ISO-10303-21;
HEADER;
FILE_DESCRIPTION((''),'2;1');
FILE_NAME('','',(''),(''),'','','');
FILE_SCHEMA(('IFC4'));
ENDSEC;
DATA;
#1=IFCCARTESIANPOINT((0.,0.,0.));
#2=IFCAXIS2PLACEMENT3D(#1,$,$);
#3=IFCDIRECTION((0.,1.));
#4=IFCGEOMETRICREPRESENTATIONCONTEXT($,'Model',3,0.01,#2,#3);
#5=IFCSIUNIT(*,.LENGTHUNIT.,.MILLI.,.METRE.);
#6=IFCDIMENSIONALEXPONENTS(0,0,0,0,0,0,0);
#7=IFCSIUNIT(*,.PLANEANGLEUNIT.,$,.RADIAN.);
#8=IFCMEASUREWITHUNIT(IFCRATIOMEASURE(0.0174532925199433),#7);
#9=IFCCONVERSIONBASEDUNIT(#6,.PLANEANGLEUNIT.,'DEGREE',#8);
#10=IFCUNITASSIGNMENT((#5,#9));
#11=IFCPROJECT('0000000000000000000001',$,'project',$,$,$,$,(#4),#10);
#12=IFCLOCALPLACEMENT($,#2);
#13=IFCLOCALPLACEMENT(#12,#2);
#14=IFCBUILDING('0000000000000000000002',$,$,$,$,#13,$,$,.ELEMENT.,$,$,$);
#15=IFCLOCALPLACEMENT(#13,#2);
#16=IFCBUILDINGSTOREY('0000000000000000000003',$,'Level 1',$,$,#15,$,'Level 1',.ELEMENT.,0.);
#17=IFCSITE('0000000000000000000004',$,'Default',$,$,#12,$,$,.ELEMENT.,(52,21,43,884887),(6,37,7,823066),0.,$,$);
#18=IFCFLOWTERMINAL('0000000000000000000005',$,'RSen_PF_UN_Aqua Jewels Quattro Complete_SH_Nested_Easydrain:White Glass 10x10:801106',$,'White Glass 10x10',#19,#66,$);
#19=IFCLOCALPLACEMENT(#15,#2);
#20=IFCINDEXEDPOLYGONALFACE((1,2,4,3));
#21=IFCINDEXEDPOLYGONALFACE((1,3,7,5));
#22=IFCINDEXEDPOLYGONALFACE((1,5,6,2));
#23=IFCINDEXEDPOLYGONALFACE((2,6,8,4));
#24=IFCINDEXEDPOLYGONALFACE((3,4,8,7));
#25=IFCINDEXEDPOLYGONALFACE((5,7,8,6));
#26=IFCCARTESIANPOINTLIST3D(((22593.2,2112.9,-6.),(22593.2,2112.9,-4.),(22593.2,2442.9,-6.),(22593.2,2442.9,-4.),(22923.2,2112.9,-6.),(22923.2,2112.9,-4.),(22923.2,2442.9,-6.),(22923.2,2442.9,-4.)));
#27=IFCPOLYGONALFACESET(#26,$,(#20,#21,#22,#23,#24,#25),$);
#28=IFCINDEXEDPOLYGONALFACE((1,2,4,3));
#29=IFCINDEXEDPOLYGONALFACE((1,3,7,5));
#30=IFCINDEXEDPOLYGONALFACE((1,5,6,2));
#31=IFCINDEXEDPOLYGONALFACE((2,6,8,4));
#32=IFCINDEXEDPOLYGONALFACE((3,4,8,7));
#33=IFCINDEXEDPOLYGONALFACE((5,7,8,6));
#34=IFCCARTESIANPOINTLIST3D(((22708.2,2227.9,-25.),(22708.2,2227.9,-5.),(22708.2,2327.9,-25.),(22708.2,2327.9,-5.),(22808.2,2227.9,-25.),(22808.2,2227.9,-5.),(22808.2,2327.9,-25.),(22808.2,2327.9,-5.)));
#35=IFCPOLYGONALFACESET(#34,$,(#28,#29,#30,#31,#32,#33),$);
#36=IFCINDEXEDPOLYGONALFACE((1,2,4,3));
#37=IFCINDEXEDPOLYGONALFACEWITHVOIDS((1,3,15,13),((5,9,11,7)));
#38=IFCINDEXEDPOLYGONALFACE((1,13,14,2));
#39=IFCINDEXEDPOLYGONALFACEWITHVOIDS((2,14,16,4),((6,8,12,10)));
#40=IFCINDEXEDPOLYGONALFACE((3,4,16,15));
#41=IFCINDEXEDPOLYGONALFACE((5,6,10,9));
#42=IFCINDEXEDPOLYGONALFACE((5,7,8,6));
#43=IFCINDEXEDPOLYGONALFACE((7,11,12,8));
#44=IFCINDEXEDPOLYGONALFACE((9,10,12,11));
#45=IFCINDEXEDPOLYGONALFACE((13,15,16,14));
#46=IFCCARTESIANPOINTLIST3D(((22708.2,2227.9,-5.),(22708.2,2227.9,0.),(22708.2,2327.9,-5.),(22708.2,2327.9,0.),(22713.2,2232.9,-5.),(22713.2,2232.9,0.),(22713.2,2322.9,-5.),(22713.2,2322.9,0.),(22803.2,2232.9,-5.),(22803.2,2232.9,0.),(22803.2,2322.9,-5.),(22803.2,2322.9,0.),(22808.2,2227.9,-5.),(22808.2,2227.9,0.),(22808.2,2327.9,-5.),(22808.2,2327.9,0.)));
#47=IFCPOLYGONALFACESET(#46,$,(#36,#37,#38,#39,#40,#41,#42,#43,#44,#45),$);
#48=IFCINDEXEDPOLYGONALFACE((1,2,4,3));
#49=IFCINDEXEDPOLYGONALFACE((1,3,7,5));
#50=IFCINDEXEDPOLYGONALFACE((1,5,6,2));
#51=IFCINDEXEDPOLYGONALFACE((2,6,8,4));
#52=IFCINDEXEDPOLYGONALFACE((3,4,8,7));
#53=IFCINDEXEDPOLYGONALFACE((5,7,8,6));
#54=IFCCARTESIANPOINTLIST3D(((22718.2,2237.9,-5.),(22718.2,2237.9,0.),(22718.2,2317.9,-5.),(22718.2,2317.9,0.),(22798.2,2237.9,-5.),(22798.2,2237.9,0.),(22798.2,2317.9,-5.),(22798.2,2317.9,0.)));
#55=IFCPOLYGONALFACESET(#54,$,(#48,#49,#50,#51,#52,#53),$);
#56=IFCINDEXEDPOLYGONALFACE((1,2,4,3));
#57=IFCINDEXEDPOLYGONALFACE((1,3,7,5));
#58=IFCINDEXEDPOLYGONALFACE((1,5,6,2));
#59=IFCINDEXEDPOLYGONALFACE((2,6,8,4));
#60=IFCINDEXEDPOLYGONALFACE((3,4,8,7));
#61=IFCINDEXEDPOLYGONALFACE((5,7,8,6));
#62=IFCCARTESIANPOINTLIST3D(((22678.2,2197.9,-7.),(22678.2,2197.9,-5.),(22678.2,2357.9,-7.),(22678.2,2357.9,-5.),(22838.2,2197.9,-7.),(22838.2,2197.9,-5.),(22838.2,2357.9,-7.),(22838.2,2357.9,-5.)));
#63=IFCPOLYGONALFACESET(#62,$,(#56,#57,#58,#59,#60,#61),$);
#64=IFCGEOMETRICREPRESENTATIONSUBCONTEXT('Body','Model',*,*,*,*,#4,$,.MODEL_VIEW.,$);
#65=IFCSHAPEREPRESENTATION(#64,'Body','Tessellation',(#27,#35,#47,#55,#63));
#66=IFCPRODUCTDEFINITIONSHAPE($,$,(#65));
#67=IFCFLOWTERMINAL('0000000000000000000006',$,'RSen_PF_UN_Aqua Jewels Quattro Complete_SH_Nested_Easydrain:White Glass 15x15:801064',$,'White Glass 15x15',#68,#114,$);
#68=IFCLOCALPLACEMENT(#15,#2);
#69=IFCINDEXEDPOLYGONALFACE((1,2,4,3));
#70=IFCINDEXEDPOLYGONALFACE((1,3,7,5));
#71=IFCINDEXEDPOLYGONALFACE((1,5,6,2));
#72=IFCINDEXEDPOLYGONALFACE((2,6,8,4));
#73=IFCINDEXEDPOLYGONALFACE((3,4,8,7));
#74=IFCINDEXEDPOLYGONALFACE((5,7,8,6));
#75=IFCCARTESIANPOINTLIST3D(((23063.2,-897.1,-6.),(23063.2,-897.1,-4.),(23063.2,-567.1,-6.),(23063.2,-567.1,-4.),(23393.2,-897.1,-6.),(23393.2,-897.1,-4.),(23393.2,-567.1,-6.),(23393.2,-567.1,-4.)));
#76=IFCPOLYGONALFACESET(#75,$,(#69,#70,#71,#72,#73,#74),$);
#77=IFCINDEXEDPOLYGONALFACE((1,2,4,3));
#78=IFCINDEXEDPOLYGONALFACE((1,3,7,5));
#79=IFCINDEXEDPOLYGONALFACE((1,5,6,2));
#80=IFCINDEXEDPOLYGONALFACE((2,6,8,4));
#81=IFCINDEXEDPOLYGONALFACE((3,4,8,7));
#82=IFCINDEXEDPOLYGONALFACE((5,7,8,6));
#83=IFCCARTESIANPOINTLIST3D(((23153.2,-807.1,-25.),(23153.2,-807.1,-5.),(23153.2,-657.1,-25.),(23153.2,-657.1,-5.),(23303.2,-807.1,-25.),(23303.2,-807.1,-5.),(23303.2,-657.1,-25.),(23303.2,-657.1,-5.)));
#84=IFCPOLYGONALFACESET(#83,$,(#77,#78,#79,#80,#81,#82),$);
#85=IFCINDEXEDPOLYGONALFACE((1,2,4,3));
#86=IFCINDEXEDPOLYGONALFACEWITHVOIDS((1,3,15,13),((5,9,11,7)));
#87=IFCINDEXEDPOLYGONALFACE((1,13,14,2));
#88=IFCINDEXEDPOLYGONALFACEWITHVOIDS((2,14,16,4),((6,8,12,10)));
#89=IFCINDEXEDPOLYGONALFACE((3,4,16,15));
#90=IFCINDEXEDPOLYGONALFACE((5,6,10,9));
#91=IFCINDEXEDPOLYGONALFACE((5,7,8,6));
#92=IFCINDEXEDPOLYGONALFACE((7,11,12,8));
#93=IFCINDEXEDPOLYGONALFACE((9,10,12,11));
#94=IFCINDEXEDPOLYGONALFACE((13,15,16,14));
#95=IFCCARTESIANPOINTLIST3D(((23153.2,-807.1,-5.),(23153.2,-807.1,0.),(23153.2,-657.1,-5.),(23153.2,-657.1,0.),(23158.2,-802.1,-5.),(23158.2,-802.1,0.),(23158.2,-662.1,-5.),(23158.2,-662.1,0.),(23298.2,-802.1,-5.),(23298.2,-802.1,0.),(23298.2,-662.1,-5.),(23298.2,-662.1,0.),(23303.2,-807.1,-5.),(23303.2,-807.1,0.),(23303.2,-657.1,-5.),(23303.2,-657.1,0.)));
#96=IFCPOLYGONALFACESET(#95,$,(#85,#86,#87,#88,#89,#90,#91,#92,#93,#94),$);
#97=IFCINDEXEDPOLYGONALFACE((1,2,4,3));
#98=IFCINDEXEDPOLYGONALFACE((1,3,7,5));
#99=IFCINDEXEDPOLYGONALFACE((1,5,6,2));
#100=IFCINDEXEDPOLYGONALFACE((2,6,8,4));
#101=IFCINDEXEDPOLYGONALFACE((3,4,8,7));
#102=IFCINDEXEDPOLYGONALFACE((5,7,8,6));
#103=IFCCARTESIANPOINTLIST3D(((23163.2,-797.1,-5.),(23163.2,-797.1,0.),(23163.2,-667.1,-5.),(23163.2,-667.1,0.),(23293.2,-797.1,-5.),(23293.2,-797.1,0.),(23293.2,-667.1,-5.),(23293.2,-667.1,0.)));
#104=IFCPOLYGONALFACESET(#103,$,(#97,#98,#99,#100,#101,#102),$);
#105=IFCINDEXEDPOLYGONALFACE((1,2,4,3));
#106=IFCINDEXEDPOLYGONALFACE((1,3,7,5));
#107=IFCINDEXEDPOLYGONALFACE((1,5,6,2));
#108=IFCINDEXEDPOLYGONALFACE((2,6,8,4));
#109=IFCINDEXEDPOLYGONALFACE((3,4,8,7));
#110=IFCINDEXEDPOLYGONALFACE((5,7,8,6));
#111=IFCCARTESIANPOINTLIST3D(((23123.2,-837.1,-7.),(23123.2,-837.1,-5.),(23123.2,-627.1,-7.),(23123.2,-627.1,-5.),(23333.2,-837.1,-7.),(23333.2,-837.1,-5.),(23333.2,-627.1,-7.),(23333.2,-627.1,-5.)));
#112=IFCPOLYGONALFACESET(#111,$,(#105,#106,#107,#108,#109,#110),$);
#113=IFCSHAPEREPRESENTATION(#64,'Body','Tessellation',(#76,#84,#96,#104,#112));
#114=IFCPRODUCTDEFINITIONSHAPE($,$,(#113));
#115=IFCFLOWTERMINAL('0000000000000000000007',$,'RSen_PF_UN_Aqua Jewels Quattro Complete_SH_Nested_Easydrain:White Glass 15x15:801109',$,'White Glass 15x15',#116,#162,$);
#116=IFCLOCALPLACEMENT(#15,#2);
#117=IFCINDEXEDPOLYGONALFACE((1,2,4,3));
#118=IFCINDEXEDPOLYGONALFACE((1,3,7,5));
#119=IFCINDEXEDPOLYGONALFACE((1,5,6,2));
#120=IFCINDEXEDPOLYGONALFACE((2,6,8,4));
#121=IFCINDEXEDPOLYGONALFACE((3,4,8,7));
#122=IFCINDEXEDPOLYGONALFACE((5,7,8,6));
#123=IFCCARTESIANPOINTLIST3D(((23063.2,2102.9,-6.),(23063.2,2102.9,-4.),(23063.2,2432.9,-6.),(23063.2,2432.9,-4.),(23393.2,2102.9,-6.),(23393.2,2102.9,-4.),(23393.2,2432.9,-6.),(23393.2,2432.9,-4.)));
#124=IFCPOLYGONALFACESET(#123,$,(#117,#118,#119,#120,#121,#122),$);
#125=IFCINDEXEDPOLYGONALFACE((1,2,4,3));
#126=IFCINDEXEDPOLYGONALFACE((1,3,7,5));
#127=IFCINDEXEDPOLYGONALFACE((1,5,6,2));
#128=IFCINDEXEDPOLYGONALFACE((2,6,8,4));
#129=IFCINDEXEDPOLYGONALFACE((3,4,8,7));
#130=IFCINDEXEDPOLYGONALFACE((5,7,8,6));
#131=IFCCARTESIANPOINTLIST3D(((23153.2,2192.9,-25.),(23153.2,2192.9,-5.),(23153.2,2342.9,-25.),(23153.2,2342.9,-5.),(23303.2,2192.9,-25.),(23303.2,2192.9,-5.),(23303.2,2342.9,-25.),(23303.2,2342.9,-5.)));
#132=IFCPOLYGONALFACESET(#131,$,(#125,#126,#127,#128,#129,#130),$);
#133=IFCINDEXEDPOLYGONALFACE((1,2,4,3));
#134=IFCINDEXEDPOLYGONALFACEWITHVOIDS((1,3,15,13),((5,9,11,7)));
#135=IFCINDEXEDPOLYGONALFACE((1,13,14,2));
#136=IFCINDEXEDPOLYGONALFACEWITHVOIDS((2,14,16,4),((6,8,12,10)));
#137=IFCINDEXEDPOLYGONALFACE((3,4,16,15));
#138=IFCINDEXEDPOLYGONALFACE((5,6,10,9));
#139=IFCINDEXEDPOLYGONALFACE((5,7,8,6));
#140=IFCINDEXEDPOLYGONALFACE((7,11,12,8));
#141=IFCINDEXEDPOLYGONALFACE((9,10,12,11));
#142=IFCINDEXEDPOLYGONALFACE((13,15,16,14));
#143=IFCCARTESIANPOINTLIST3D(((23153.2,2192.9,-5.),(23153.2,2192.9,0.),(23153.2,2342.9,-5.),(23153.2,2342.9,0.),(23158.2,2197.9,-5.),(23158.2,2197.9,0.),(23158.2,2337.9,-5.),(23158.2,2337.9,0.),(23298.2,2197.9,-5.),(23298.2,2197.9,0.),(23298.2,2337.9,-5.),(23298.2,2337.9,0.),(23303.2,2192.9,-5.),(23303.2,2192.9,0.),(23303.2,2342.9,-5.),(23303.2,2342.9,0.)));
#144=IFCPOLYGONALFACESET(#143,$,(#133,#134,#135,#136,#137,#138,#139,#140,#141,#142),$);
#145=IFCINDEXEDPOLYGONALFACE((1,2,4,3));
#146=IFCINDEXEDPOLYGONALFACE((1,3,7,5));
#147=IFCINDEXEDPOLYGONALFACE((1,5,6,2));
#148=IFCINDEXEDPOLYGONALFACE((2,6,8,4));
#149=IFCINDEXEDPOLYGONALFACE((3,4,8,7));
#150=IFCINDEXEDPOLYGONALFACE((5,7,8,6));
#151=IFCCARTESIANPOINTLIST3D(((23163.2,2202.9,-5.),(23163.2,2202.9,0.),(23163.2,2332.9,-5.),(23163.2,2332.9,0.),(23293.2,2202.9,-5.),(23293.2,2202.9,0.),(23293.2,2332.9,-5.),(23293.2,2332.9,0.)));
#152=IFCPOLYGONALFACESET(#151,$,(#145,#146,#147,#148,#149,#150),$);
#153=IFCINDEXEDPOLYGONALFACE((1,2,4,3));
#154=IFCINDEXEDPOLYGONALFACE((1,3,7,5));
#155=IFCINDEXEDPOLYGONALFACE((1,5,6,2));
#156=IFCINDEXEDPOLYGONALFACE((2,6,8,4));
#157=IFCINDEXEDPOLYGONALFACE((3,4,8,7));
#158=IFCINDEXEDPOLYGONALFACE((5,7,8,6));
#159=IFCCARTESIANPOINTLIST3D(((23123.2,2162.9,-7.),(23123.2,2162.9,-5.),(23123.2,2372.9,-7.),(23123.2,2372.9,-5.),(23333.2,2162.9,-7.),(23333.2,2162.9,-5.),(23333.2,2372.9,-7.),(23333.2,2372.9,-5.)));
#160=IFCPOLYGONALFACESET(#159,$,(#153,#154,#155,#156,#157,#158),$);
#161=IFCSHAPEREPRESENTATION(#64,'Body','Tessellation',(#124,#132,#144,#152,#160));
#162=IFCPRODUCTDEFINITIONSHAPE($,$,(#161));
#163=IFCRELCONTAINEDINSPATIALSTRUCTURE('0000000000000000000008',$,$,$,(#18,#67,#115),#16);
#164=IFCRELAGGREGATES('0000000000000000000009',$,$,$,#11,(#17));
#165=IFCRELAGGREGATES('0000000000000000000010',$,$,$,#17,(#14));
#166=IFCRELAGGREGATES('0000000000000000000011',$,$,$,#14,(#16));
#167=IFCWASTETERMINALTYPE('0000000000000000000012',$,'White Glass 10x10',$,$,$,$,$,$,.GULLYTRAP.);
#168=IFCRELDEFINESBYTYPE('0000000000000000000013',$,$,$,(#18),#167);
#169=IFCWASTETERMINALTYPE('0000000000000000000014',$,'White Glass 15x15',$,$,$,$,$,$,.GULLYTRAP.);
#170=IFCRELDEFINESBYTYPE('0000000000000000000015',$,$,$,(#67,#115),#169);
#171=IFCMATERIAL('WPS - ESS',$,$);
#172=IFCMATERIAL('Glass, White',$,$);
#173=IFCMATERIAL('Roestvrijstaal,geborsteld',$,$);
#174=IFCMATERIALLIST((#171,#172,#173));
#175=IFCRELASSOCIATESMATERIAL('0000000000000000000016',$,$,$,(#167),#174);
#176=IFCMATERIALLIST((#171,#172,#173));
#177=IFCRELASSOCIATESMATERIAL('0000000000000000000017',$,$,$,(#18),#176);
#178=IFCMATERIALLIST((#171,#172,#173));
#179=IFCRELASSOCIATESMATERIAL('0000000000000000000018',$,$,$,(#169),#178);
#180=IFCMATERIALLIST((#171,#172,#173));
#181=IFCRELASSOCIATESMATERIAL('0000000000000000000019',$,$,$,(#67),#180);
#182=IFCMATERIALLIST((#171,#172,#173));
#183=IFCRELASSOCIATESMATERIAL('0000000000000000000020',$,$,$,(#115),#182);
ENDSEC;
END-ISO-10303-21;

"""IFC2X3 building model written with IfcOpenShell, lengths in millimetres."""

from ifc_helpers import new_model, entity, si_unit, converted_unit, direction, frame, frame_2d, origin, origin_2d_with_axis, place, context, subcontext, project, spatial, polyline, rectangle, outline, extrude, source, transform, mapped, material, material_list, type_object, type_shapes, element, save


model = new_model("IFC2X3")

# Units and contexts
model_context = context("Model", 3, precision=0.01, world=origin(), true_north=direction((0.0, 1.0)))
body_context = subcontext(model_context, "Body", "Model", "MODEL_VIEW")
ifc_project = project(units=[si_unit("LENGTHUNIT", "METRE", prefix="MILLI"), converted_unit("PLANEANGLEUNIT", "DEGREE", entity("IfcRatioMeasure", 0.0174532925199433), si_unit("PLANEANGLEUNIT", "RADIAN"), dimensions=[0, 0, 0, 0, 0, 0, 0])], contexts=[model_context])

# Site, building, storey
site_placement = place(None, origin())
site = spatial("IfcSite", under=ifc_project, at=site_placement, Name="Default", CompositionType="ELEMENT", RefLatitude=(52, 21, 43, 884887), RefLongitude=(6, 37, 7, 823066), RefElevation=0.0)
building_placement = place(site_placement, origin())
building = spatial("IfcBuilding", under=site, at=building_placement, CompositionType="ELEMENT")
storey_placement = place(building_placement, origin())
storey = spatial("IfcBuildingStorey", under=building, at=storey_placement, Name="Level 1", LongName="Level 1", CompositionType="ELEMENT", Elevation=0.0)

# Flow terminals
ifc_material_1 = material(Name="WPS - ESS")
ifc_material_2 = material(Name="Roestvrijstaal,geborsteld")
ifc_material_3 = material(Name="Glass, White")
ifc_material_list_1 = material_list([ifc_material_1, ifc_material_3, ifc_material_2])
waste_terminal_type_1 = type_object("IfcWasteTerminalType", Name="White Glass 10x10", PredefinedType="GULLYTRAP", material=ifc_material_list_1)
shared_shape_1 = source(origin(), body_context, "Body", "SweptSolid", [
    extrude(rectangle(XDim=330.0, YDim=330.0, at=origin_2d_with_axis()), frame((0.0, 0.0, -6.0), z_axis=(0.0, 0.0, 1.0), x_axis=(-1.0, 0.0, 0.0)), (0.0, 0.0, 1.0), 2.0),
    extrude(rectangle(XDim=100.0, YDim=100.0, at=origin_2d_with_axis()), frame((0.0, 0.0, -25.0), z_axis=(0.0, 0.0, 1.0), x_axis=(-1.0, 0.0, 0.0)), (0.0, 0.0, 1.0), 20.0),
    extrude(outline(polyline([(-50.0, -50.0), (50.0, -50.0), (50.0, 50.0), (-50.0, 50.0), (-50.0, -50.0)]), holes=[polyline([(-45.0, -45.0), (-45.0, 45.0), (45.0, 45.0), (45.0, -45.0), (-45.0, -45.0)])]), frame((0.0, 0.0, -5.0), z_axis=(0.0, 0.0, 1.0), x_axis=(-1.0, 0.0, 0.0)), (0.0, 0.0, 1.0), 5.0),
    extrude(rectangle(XDim=80.0, YDim=80.0, at=origin_2d_with_axis()), frame((0.0, 0.0, -5.0), z_axis=(0.0, 0.0, 1.0), x_axis=(-1.0, 0.0, 0.0)), (0.0, 0.0, 1.0), 5.0),
    extrude(rectangle(XDim=160.0, YDim=160.0, at=origin_2d_with_axis()), frame((0.0, 0.0, -7.0), z_axis=(0.0, 0.0, 1.0), x_axis=(-1.0, 0.0, 0.0)), (0.0, 0.0, 1.0), 2.0),
])
type_shapes(waste_terminal_type_1, [shared_shape_1])
ifc_material_list_2 = material_list([ifc_material_1, ifc_material_3, ifc_material_2])
flow_terminal_1_placement = place(storey_placement, frame((22758.2, 2277.9, 0.0)))
element("IfcFlowTerminal", 1, at=flow_terminal_1_placement, inside=storey, type_object=waste_terminal_type_1, material=ifc_material_list_2, Name="RSen_PF_UN_Aqua Jewels Quattro Complete_SH_Nested_Easydrain:White Glass 10x10:801106", ObjectType="White Glass 10x10", context=body_context, shape_type="MappedRepresentation", body=[
    mapped(shared_shape_1, transform((0.0, 0.0, 0.0), scale=1.0)),
])
ifc_material_list_3 = material_list([ifc_material_1, ifc_material_3, ifc_material_2])
ifc_material_list_4 = material_list([ifc_material_1, ifc_material_3, ifc_material_2])
waste_terminal_type_2 = type_object("IfcWasteTerminalType", Name="White Glass 15x15", PredefinedType="GULLYTRAP", material=ifc_material_list_4)
shared_shape_2 = source(origin(), body_context, "Body", "SweptSolid", [
    extrude(rectangle(XDim=330.0, YDim=330.0, at=origin_2d_with_axis()), frame((5.0, -10.0, -6.0), z_axis=(0.0, 0.0, 1.0), x_axis=(-1.0, 0.0, 0.0)), (0.0, 0.0, 1.0), 2.0),
    extrude(rectangle(XDim=150.0, YDim=150.0, at=origin_2d_with_axis()), frame((5.0, -10.0, -25.0), z_axis=(0.0, 0.0, 1.0), x_axis=(-1.0, 0.0, 0.0)), (0.0, 0.0, 1.0), 20.0),
    extrude(outline(polyline([(-75.0, -75.0), (75.0, -75.0), (75.0, 75.0), (-75.0, 75.0), (-75.0, -75.0)]), holes=[polyline([(-70.0, -70.0), (-70.0, 70.0), (70.0, 70.0), (70.0, -70.0), (-70.0, -70.0)])]), frame((5.0, -10.0, -5.0), z_axis=(0.0, 0.0, 1.0), x_axis=(-1.0, 0.0, 0.0)), (0.0, 0.0, 1.0), 5.0),
    extrude(rectangle(XDim=130.0, YDim=130.0, at=frame_2d((0.0, 0.0), x_axis=(1.0, 0.0))), frame((5.0, -10.0, -5.0), z_axis=(0.0, 0.0, 1.0), x_axis=(-1.0, 0.0, 0.0)), (0.0, 0.0, 1.0), 5.0),
    extrude(rectangle(XDim=210.0, YDim=210.0, at=origin_2d_with_axis()), frame((5.0, -10.0, -7.0), z_axis=(0.0, 0.0, 1.0), x_axis=(-1.0, 0.0, 0.0)), (0.0, 0.0, 1.0), 2.0),
])
type_shapes(waste_terminal_type_2, [shared_shape_2])
flow_terminal_2_placement = place(storey_placement, frame((23223.2, -722.1, 0.0)))
element("IfcFlowTerminal", 2, at=flow_terminal_2_placement, inside=storey, type_object=waste_terminal_type_2, material=ifc_material_list_3, Name="RSen_PF_UN_Aqua Jewels Quattro Complete_SH_Nested_Easydrain:White Glass 15x15:801064", ObjectType="White Glass 15x15", context=body_context, shape_type="MappedRepresentation", body=[
    mapped(shared_shape_2, transform((0.0, 0.0, 0.0), scale=1.0)),
])
ifc_material_list_5 = material_list([ifc_material_1, ifc_material_3, ifc_material_2])
flow_terminal_3_placement = place(storey_placement, frame((23223.2, 2277.9, 0.0)))
element("IfcFlowTerminal", 3, at=flow_terminal_3_placement, inside=storey, type_object=waste_terminal_type_2, material=ifc_material_list_5, Name="RSen_PF_UN_Aqua Jewels Quattro Complete_SH_Nested_Easydrain:White Glass 15x15:801109", ObjectType="White Glass 15x15", context=body_context, shape_type="MappedRepresentation", body=[
    mapped(shared_shape_2, transform((0.0, 0.0, 0.0), scale=1.0)),
])

save(model, "model.ifc")
